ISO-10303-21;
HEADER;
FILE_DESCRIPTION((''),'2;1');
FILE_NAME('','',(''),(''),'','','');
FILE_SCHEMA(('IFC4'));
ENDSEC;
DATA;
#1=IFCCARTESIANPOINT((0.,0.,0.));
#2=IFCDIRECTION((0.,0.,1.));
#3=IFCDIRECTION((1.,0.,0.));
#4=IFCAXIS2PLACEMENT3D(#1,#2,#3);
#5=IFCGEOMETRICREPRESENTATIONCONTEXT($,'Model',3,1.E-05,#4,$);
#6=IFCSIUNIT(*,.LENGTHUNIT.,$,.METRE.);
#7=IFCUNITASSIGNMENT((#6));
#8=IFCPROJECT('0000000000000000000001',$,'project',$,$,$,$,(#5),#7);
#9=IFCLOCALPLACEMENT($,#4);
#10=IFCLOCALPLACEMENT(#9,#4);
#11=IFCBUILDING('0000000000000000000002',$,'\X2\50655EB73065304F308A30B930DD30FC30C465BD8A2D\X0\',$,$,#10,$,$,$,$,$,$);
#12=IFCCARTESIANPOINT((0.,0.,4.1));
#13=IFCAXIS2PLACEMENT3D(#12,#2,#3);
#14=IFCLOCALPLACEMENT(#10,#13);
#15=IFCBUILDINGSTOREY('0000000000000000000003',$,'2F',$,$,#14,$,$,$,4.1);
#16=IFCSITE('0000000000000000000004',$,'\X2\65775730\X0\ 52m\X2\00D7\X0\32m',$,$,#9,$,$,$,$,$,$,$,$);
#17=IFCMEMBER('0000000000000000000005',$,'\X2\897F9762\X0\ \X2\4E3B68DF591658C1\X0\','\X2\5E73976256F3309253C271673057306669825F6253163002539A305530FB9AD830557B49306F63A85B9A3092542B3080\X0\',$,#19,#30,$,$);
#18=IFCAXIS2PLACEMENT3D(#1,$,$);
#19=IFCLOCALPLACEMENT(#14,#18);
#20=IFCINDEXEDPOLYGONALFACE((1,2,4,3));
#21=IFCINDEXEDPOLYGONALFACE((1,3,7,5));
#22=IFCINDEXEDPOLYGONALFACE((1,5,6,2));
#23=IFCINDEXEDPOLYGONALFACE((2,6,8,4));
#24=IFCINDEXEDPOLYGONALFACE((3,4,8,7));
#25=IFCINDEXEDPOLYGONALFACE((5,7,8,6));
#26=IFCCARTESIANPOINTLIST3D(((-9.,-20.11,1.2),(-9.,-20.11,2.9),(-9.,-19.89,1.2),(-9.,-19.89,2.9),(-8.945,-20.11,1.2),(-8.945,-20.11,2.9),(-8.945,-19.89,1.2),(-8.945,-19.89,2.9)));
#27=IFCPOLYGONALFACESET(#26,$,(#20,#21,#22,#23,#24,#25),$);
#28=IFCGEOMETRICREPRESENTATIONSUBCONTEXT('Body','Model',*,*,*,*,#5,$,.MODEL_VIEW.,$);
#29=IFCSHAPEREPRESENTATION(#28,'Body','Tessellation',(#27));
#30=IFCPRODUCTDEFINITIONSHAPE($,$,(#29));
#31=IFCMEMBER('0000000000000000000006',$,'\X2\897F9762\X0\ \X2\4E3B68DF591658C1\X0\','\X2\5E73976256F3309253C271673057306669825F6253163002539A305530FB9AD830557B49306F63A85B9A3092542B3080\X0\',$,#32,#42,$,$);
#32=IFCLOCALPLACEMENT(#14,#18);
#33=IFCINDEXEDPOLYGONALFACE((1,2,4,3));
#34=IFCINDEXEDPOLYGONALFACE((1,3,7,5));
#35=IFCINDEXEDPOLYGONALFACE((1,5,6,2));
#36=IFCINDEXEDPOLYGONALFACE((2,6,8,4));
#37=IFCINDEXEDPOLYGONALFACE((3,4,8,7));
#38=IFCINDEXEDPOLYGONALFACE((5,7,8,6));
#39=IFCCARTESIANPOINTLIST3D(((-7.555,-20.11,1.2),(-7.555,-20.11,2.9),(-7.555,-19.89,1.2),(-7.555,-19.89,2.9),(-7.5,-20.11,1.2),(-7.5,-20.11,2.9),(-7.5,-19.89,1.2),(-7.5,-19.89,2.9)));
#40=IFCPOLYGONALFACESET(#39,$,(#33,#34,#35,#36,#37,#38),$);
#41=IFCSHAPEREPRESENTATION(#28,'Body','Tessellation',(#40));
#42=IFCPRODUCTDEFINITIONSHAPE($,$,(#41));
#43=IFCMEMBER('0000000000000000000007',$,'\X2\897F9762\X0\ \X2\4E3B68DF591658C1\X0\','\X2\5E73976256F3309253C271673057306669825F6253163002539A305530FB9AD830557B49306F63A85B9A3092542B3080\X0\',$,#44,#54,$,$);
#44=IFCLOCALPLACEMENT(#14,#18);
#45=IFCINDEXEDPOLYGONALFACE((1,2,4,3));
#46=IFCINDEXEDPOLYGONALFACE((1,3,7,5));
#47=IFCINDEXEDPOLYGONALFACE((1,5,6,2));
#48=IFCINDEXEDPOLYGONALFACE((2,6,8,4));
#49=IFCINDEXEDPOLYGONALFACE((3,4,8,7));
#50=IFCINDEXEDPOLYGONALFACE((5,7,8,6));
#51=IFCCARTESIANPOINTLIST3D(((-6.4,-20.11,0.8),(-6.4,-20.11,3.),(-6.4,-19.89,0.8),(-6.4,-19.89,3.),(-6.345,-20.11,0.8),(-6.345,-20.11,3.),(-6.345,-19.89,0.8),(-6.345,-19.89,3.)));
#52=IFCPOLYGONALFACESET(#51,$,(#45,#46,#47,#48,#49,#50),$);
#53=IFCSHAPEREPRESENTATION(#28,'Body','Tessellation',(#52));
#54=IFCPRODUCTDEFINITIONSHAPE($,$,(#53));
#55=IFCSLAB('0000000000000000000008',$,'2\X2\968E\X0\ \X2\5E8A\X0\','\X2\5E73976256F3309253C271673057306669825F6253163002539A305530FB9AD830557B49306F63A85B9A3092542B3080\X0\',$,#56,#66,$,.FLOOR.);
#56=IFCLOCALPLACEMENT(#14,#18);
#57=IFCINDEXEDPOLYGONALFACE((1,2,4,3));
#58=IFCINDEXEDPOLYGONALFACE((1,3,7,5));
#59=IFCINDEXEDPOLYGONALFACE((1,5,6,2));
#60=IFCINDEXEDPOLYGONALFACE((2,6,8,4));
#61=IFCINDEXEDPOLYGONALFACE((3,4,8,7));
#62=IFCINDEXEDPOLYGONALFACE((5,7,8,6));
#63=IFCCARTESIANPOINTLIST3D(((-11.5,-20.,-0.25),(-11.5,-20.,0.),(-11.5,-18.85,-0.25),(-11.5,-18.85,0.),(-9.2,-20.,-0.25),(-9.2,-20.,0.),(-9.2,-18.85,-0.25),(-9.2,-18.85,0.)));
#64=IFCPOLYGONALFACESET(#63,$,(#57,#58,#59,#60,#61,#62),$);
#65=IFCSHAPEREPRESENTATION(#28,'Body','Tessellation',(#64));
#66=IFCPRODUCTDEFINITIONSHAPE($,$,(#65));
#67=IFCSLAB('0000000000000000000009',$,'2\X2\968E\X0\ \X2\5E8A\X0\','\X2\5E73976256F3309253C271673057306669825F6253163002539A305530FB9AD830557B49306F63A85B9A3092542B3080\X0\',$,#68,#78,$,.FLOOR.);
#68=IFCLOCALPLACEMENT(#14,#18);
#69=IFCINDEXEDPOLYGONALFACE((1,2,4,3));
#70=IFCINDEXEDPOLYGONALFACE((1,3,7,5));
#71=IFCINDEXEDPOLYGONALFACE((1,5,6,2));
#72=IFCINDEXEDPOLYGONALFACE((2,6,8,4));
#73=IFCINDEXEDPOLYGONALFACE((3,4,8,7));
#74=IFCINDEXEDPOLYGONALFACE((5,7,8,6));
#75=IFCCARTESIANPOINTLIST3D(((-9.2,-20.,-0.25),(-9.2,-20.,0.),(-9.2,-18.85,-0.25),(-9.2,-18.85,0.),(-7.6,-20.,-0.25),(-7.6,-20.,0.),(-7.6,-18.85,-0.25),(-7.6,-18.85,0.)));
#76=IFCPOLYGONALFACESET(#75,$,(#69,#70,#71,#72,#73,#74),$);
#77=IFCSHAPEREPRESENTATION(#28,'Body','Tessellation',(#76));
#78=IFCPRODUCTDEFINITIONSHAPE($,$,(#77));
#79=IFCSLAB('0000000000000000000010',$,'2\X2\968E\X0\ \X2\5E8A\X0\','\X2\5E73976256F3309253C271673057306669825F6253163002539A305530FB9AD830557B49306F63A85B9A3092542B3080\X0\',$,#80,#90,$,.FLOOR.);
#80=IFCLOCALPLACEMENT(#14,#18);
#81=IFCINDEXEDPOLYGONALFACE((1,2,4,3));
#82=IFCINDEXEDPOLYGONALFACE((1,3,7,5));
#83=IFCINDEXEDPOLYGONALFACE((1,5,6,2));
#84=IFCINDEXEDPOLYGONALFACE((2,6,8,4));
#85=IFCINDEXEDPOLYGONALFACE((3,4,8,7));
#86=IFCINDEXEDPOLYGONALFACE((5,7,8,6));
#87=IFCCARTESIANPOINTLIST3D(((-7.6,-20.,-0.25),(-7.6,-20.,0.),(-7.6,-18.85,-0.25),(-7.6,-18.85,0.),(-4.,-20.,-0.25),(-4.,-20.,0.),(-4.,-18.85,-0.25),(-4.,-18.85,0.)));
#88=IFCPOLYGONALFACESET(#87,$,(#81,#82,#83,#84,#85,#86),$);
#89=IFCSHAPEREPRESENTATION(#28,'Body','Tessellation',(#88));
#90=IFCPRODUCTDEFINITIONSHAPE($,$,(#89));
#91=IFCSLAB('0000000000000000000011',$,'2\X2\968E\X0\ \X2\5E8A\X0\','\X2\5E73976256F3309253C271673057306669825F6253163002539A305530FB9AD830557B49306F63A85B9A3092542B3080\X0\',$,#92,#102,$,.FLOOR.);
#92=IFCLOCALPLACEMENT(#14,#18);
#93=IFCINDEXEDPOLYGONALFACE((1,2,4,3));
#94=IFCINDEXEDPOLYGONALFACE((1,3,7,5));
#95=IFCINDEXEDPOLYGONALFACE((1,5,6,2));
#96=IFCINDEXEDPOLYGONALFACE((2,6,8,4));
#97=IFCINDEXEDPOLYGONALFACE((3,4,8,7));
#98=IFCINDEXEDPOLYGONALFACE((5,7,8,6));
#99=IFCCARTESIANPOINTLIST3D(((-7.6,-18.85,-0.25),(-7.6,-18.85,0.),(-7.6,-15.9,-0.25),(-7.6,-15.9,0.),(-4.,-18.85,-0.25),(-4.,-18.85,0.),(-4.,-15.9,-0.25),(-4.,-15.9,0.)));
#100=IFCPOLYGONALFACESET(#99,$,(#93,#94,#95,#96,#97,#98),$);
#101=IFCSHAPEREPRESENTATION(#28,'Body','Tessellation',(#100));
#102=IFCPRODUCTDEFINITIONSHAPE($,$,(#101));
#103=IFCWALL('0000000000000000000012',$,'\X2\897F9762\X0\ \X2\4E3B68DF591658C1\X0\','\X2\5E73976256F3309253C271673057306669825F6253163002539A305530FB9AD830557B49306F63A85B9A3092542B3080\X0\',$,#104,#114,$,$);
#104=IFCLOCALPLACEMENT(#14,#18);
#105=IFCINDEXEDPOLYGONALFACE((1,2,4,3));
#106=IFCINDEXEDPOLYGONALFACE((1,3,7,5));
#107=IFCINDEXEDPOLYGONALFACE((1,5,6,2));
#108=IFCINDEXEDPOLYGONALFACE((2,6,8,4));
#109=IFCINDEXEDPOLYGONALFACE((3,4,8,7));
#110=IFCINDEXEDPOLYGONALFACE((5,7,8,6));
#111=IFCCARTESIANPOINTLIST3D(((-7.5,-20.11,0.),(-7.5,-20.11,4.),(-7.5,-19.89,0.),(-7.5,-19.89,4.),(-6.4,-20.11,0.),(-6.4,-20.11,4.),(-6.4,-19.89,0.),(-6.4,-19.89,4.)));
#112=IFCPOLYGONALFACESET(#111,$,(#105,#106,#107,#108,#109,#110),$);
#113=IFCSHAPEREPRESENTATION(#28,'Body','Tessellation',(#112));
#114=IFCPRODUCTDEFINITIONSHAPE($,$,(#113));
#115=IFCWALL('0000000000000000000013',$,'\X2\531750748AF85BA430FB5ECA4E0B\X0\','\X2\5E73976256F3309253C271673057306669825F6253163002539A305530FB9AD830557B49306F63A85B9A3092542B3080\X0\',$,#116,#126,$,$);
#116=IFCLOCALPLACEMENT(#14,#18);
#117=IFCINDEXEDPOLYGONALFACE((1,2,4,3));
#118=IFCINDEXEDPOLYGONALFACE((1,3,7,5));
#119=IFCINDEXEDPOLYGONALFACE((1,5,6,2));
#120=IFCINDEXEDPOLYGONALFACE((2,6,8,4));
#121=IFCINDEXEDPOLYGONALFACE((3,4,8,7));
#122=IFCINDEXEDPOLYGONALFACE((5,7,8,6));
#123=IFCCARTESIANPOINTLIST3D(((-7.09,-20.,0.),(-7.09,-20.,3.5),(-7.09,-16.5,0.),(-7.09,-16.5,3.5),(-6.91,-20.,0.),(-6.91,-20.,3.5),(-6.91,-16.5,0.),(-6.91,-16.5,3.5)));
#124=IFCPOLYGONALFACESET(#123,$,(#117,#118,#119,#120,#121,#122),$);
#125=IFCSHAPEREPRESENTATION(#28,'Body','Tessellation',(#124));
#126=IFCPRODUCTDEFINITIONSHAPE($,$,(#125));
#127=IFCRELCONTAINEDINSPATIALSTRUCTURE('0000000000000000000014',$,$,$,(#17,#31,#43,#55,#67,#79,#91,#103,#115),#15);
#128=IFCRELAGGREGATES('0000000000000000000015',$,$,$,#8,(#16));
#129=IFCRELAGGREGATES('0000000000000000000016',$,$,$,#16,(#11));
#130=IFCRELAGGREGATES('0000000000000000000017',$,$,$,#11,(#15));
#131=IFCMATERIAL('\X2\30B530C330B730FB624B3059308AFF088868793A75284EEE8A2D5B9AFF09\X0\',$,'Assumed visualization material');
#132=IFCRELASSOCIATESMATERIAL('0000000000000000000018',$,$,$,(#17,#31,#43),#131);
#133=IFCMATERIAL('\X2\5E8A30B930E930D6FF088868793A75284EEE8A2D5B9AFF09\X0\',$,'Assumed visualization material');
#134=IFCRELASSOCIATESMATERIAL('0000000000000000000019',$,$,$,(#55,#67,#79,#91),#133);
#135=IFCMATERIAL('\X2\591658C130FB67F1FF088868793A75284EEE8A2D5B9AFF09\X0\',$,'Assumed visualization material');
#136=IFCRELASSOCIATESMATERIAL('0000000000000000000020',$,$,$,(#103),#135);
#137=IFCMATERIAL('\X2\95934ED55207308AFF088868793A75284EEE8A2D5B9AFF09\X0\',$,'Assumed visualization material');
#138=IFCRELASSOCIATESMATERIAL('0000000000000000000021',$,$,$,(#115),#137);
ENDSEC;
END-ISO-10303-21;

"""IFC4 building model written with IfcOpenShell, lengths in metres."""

from ifc_helpers import new_model, si_unit, frame, origin_with_axes, place, context, subcontext, project, spatial, rectangle, extrude, material, element, save


model = new_model("IFC4")

# Units and contexts
model_context = context("Model", 3, precision=1e-05, world=origin_with_axes())
body_context = subcontext(model_context, "Body", "Model", "MODEL_VIEW")
ifc_project = project(units=[si_unit("LENGTHUNIT", "METRE")], contexts=[model_context])

# Site, building, storey
site_placement = place(None, origin_with_axes())
site = spatial("IfcSite", under=ifc_project, at=site_placement, Name="敷地 52m×32m")
building_placement = place(site_placement, origin_with_axes())
building = spatial("IfcBuilding", under=site, at=building_placement, Name="健康づくりスポーツ施設")
storey_placement = place(building_placement, frame((0.0, 0.0, 4.1), z_axis=(0.0, 0.0, 1.0), x_axis=(1.0, 0.0, 0.0)))
storey = spatial("IfcBuildingStorey", under=building, at=storey_placement, Name="2F", Elevation=4.1)

# Members
ifc_material_1 = material(Name="サッシ・手すり（表示用仮設定）", Category="Assumed visualization material")
for number, where, z_axis, x_axis, name in (
    (1, (-8.9725, -20.0, 1.2), (0.0, 0.0, 1.0), (1.0, 0.0, 0.0), "西面 主棟外壁"),
    (2, (-7.5275, -20.0, 1.2), (0.0, 0.0, 1.0), (1.0, 0.0, 0.0), "西面 主棟外壁"),
):
    element("IfcMember", number, at=place(storey_placement, frame(where, z_axis=z_axis, x_axis=x_axis)), inside=storey, material=ifc_material_1, Name=name, Description="平面図を参照して概形化。厚さ・高さ等は推定を含む", context=body_context, shape_type="SweptSolid", body=[
        extrude(rectangle(XDim=0.055, YDim=0.22), origin_with_axes(), (0.0, 0.0, 1.0), 1.7),
    ])
member_placement = place(storey_placement, frame((-6.3725, -20.0, 0.8), z_axis=(0.0, 0.0, 1.0), x_axis=(1.0, 0.0, 0.0)))
element("IfcMember", 3, at=member_placement, inside=storey, material=ifc_material_1, Name="西面 主棟外壁", Description="平面図を参照して概形化。厚さ・高さ等は推定を含む", context=body_context, shape_type="SweptSolid", body=[
    extrude(rectangle(XDim=0.055, YDim=0.22), origin_with_axes(), (0.0, 0.0, 1.0), 2.2),
])

# Slabs
ifc_material_2 = material(Name="床スラブ（表示用仮設定）", Category="Assumed visualization material")
slab_1_placement = place(storey_placement, frame((-10.35, -19.425, -0.25), z_axis=(0.0, 0.0, 1.0), x_axis=(1.0, 0.0, 0.0)))
element("IfcSlab", 4, at=slab_1_placement, inside=storey, material=ifc_material_2, Name="2階 床", Description="平面図を参照して概形化。厚さ・高さ等は推定を含む", PredefinedType="FLOOR", context=body_context, shape_type="SweptSolid", body=[
    extrude(rectangle(XDim=2.3, YDim=1.15), origin_with_axes(), (0.0, 0.0, 1.0), 0.25),
])
slab_2_placement = place(storey_placement, frame((-8.4, -19.425, -0.25), z_axis=(0.0, 0.0, 1.0), x_axis=(1.0, 0.0, 0.0)))
element("IfcSlab", 5, at=slab_2_placement, inside=storey, material=ifc_material_2, Name="2階 床", Description="平面図を参照して概形化。厚さ・高さ等は推定を含む", PredefinedType="FLOOR", context=body_context, shape_type="SweptSolid", body=[
    extrude(rectangle(XDim=1.6, YDim=1.15), origin_with_axes(), (0.0, 0.0, 1.0), 0.25),
])
slab_3_placement = place(storey_placement, frame((-5.8, -19.425, -0.25), z_axis=(0.0, 0.0, 1.0), x_axis=(1.0, 0.0, 0.0)))
element("IfcSlab", 6, at=slab_3_placement, inside=storey, material=ifc_material_2, Name="2階 床", Description="平面図を参照して概形化。厚さ・高さ等は推定を含む", PredefinedType="FLOOR", context=body_context, shape_type="SweptSolid", body=[
    extrude(rectangle(XDim=3.6, YDim=1.15), origin_with_axes(), (0.0, 0.0, 1.0), 0.25),
])
slab_4_placement = place(storey_placement, frame((-5.8, -17.375, -0.25), z_axis=(0.0, 0.0, 1.0), x_axis=(1.0, 0.0, 0.0)))
element("IfcSlab", 7, at=slab_4_placement, inside=storey, material=ifc_material_2, Name="2階 床", Description="平面図を参照して概形化。厚さ・高さ等は推定を含む", PredefinedType="FLOOR", context=body_context, shape_type="SweptSolid", body=[
    extrude(rectangle(XDim=3.6, YDim=2.95), origin_with_axes(), (0.0, 0.0, 1.0), 0.25),
])

# Walls
ifc_material_3 = material(Name="外壁・柱（表示用仮設定）", Category="Assumed visualization material")
wall_1_placement = place(storey_placement, frame((-6.95, -20.0, 0.0), z_axis=(0.0, 0.0, 1.0), x_axis=(1.0, 0.0, 0.0)))
element("IfcWall", 8, at=wall_1_placement, inside=storey, material=ifc_material_3, Name="西面 主棟外壁", Description="平面図を参照して概形化。厚さ・高さ等は推定を含む", context=body_context, shape_type="SweptSolid", body=[
    extrude(rectangle(XDim=1.1, YDim=0.22), origin_with_axes(), (0.0, 0.0, 1.0), 4.0),
])
ifc_material_4 = material(Name="間仕切り（表示用仮設定）", Category="Assumed visualization material")
wall_2_placement = place(storey_placement, frame((-7.0, -18.25, 0.0), z_axis=(0.0, 0.0, 1.0), x_axis=(1.0, 0.0, 0.0)))
element("IfcWall", 9, at=wall_2_placement, inside=storey, material=ifc_material_4, Name="北側諸室・廊下", Description="平面図を参照して概形化。厚さ・高さ等は推定を含む", context=body_context, shape_type="SweptSolid", body=[
    extrude(rectangle(XDim=0.18, YDim=3.5), origin_with_axes(), (0.0, 0.0, 1.0), 3.5),
])

save(model, "model.ifc")
